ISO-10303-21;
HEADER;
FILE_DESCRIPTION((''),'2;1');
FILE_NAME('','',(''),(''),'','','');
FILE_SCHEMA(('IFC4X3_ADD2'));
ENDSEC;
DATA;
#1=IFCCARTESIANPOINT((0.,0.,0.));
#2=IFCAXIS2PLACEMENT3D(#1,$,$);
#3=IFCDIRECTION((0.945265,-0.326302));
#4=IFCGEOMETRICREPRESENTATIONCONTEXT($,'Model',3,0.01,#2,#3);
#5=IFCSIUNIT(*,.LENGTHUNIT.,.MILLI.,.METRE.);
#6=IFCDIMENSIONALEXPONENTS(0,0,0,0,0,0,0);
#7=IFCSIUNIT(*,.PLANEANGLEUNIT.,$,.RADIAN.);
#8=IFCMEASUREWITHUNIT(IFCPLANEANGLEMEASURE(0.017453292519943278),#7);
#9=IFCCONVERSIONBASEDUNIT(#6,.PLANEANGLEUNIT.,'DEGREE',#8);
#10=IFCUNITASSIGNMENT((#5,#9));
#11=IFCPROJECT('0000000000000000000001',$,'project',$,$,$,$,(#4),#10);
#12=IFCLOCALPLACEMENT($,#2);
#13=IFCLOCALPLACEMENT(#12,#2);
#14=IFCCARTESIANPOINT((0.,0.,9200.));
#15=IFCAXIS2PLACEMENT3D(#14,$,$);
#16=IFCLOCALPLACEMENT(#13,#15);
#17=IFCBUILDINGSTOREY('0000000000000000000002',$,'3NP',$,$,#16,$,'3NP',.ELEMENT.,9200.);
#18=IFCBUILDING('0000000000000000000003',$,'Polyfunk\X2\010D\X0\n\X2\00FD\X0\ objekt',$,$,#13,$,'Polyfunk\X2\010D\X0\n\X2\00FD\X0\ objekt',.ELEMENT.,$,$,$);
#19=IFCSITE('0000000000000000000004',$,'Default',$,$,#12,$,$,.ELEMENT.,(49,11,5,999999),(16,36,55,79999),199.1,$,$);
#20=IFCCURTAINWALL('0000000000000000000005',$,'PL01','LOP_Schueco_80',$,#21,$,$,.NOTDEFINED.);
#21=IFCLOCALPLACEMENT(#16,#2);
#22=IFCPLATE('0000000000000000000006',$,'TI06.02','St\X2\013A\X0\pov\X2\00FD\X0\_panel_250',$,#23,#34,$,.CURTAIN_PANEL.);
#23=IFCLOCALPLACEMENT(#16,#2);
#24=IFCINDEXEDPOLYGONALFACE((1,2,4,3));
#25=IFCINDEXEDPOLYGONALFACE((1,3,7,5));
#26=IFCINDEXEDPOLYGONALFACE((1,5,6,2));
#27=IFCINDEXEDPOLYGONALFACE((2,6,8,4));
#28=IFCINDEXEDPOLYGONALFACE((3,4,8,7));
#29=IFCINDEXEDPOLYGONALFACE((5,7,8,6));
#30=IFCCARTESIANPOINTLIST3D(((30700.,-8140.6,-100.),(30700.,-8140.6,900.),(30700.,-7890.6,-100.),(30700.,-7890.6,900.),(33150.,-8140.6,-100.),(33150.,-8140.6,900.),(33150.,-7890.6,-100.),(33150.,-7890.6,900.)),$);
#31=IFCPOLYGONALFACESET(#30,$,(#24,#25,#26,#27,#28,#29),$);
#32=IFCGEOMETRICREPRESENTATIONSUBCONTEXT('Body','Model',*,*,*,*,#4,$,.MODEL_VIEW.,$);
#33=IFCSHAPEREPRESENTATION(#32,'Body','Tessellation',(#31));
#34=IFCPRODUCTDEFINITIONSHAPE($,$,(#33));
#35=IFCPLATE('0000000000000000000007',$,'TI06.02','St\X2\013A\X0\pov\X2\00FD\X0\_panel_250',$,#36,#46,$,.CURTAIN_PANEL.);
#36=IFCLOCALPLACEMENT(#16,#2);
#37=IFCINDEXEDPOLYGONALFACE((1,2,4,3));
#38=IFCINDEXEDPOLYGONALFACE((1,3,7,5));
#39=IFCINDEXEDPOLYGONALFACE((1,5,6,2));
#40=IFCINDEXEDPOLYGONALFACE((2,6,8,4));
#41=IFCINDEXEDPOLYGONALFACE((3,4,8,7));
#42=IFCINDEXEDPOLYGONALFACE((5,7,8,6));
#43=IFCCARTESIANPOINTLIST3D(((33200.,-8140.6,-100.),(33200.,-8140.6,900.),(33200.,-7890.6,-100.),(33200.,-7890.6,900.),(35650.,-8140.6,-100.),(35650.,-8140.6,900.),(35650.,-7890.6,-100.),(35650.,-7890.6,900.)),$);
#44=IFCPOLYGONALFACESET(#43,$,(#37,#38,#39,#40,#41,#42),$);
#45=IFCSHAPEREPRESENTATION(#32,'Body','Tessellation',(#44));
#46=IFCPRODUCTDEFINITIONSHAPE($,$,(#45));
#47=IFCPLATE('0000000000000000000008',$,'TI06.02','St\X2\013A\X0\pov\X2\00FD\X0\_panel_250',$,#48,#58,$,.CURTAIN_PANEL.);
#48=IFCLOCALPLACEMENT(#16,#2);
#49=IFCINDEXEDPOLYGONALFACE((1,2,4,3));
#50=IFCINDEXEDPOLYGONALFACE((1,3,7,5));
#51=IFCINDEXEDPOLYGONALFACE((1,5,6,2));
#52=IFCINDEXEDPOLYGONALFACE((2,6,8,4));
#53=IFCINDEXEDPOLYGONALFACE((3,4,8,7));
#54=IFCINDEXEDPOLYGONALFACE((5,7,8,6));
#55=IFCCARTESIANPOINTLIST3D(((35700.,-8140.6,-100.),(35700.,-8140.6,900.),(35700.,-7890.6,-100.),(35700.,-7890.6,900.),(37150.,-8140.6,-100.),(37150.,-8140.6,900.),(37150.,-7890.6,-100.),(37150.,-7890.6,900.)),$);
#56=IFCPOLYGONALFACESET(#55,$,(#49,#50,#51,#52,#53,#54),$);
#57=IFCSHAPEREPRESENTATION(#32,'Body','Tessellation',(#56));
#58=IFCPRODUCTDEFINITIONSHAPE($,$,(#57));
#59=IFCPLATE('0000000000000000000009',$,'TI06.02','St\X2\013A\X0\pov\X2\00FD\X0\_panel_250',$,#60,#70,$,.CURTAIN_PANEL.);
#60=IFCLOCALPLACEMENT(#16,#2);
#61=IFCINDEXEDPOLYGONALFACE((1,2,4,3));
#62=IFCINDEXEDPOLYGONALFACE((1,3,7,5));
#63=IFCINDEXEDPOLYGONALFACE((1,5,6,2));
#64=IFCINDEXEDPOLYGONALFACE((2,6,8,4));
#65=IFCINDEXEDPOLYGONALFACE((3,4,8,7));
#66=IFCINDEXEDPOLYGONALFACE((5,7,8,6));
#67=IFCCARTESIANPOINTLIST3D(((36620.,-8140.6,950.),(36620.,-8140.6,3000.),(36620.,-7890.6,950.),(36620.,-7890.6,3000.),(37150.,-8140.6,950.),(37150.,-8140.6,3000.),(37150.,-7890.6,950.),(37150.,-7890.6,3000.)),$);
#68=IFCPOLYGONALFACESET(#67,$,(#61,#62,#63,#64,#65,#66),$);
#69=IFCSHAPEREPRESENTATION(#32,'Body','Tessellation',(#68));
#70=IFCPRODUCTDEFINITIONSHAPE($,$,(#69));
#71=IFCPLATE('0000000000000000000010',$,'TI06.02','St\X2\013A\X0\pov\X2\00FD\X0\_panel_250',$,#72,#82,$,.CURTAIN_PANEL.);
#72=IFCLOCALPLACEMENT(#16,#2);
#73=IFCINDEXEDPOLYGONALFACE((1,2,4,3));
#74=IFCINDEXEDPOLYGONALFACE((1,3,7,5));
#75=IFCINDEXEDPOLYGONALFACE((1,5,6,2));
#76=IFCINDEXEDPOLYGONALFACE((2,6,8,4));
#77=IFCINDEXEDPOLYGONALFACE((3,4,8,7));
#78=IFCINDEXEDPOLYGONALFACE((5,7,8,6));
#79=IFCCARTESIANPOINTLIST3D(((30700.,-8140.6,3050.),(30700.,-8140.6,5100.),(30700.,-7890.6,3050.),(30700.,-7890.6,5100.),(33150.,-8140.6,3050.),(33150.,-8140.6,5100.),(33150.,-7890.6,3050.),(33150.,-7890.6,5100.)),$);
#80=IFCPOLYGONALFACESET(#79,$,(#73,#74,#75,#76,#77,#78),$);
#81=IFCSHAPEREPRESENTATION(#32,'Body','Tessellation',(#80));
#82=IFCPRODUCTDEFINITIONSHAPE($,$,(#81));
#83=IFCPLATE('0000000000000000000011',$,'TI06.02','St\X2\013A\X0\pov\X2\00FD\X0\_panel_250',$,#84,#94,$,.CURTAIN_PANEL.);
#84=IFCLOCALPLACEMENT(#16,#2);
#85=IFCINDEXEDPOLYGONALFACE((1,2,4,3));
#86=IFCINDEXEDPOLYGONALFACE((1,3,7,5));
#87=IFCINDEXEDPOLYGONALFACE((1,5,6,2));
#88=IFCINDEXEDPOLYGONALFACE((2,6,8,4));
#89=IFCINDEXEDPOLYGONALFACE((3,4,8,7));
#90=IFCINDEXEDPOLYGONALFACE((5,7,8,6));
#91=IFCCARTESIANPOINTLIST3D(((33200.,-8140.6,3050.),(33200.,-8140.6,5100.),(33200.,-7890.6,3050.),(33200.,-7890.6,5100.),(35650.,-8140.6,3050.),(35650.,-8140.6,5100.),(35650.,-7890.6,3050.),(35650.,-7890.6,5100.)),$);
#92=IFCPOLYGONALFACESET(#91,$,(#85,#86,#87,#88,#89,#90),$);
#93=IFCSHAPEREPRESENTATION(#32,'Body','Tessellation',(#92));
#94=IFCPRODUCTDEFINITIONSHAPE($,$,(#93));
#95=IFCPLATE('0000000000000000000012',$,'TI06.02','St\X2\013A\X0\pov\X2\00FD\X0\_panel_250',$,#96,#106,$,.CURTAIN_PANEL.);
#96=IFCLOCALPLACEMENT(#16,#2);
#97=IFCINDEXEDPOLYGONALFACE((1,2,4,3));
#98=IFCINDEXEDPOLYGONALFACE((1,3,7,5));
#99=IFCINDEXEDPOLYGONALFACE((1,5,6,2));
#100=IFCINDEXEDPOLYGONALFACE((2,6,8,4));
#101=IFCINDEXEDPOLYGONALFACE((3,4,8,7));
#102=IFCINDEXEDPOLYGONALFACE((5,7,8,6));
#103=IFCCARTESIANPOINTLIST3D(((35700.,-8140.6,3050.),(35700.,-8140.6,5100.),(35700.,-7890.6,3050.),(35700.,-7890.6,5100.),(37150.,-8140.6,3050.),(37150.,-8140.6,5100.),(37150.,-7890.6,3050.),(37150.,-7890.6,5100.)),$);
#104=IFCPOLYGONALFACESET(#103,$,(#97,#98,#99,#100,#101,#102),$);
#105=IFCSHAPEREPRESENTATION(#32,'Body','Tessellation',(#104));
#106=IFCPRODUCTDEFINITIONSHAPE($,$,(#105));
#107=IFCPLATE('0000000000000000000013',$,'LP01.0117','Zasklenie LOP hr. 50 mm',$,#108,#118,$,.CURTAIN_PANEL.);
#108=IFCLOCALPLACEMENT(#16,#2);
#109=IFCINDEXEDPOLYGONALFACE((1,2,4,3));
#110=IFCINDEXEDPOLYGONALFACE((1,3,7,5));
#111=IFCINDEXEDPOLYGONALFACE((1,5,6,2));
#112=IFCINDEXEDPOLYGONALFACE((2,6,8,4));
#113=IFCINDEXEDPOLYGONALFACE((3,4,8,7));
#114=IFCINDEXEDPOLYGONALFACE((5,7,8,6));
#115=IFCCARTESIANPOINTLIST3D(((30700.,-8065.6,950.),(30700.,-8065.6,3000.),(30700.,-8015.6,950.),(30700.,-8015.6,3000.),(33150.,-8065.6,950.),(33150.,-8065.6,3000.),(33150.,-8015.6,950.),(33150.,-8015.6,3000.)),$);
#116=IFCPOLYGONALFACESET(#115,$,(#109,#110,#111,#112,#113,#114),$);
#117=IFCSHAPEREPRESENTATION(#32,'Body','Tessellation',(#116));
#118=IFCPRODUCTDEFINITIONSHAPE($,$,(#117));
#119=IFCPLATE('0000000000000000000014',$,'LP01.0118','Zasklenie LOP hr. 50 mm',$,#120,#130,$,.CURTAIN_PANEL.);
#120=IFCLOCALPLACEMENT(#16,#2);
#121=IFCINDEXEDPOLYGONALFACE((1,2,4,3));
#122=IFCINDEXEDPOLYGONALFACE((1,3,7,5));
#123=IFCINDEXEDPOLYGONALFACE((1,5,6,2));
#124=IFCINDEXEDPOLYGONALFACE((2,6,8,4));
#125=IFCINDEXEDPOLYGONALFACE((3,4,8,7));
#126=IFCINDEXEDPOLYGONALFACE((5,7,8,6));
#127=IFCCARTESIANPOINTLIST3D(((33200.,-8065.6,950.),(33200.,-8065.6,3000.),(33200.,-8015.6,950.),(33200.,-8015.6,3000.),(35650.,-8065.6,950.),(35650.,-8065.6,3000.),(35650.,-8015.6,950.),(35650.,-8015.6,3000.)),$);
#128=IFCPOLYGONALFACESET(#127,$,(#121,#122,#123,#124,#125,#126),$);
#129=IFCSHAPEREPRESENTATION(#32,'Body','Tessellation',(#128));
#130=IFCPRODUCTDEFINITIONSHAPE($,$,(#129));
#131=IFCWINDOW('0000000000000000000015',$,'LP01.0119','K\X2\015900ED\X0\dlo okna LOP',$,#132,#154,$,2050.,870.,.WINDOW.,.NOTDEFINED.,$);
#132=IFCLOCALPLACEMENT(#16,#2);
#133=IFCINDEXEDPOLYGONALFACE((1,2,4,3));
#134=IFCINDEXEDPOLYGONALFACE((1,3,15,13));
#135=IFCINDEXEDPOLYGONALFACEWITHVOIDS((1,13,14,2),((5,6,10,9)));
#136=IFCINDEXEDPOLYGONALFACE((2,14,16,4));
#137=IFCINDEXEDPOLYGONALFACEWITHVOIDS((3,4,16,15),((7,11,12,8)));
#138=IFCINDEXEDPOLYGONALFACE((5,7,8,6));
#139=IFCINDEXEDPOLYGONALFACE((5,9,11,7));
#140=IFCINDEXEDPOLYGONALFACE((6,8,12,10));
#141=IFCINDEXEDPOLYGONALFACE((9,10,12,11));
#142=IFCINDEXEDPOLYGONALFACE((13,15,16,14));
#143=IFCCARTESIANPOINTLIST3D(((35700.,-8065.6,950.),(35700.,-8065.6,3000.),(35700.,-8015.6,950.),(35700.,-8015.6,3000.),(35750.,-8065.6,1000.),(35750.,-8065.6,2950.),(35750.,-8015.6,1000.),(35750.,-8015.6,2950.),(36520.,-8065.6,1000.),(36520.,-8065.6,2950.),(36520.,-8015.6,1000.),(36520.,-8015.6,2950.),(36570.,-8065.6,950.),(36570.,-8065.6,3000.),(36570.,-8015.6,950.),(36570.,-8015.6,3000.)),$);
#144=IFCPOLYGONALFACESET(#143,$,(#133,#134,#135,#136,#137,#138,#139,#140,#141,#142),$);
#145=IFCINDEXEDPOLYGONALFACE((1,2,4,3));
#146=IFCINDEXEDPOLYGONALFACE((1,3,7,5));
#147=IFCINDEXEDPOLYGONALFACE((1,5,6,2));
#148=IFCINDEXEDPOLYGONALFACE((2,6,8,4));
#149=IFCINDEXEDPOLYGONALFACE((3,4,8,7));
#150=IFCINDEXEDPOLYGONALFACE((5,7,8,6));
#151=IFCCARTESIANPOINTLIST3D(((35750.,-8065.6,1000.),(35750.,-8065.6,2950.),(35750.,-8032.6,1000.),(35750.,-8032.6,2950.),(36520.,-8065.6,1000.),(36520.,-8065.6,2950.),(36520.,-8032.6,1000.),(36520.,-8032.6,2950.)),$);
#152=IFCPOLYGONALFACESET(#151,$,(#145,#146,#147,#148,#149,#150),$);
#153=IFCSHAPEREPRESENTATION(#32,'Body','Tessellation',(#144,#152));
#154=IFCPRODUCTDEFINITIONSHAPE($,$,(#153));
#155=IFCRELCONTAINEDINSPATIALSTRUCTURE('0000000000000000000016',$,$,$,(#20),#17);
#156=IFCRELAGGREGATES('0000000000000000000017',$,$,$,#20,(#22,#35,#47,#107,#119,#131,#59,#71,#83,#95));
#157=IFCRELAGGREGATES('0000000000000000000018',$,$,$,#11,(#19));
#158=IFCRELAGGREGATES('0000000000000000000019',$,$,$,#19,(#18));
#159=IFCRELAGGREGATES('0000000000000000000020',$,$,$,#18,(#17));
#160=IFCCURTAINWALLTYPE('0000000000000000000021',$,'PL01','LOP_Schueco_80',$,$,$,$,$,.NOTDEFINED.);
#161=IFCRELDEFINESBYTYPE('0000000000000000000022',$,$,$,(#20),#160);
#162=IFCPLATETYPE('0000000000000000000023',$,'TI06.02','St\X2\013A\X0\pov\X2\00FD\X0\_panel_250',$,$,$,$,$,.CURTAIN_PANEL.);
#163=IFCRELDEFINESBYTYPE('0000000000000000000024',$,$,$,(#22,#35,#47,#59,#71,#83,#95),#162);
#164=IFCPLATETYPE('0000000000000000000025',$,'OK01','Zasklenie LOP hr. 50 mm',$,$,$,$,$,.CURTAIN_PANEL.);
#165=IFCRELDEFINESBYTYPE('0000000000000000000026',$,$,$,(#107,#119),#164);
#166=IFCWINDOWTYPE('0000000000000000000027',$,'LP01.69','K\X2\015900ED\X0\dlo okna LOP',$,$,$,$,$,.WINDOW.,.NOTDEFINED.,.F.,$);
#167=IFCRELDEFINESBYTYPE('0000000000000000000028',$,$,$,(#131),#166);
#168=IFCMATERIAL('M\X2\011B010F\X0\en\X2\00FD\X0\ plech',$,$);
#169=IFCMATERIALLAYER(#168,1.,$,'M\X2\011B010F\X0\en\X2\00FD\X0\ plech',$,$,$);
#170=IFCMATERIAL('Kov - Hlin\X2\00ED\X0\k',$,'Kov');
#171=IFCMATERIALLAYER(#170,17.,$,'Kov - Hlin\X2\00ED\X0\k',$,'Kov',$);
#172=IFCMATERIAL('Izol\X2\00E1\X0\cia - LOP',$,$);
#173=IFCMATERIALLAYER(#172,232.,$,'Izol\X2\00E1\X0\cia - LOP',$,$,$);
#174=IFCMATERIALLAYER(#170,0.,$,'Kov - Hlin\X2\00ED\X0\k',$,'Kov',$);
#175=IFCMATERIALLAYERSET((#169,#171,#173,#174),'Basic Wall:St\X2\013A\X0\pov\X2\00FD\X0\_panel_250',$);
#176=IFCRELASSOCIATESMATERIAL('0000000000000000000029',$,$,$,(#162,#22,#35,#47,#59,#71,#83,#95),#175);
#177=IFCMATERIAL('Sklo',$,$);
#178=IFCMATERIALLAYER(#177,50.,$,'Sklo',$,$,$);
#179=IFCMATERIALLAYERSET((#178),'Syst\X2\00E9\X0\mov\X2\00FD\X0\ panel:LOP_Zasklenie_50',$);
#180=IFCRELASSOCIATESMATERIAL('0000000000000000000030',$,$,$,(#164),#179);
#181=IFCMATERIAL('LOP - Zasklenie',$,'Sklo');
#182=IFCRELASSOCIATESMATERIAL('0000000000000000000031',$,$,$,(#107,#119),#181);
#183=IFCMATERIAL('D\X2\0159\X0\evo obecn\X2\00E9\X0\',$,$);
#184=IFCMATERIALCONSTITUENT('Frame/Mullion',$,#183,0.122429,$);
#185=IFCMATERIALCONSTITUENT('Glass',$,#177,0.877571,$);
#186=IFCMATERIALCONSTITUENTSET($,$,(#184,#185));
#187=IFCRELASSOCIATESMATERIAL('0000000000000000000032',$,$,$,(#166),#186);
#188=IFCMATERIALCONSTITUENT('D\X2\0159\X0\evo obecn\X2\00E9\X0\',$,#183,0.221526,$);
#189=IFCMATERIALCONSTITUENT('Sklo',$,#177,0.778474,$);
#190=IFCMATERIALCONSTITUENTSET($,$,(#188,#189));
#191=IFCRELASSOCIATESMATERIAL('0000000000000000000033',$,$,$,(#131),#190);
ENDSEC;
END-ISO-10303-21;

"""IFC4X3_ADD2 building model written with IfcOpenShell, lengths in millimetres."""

from ifc_helpers import new_model, entity, si_unit, converted_unit, direction, frame, frame_2d, origin, origin_2d_with_axis, place, context, subcontext, project, spatial, polyline, rectangle, outline, extrude, source, transform, mapped, material, layer, layer_set, layer_usage, constituent, constituent_set, type_object, type_shapes, element, aggregate, save


model = new_model("IFC4X3_ADD2")

# Units and contexts
model_context = context("Model", 3, precision=0.01, world=origin(), true_north=direction((0.945265, -0.326302)))
body_context = subcontext(model_context, "Body", "Model", "MODEL_VIEW")
ifc_project = project(units=[si_unit("LENGTHUNIT", "METRE", prefix="MILLI"), converted_unit("PLANEANGLEUNIT", "DEGREE", entity("IfcPlaneAngleMeasure", 0.017453292519943278), si_unit("PLANEANGLEUNIT", "RADIAN"), dimensions=[0, 0, 0, 0, 0, 0, 0])], contexts=[model_context])

# Site, building, storey
site_placement = place(None, origin())
site = spatial("IfcSite", under=ifc_project, at=site_placement, Name="Default", CompositionType="ELEMENT", RefLatitude=(49, 11, 5, 999999), RefLongitude=(16, 36, 55, 79999), RefElevation=199.1)
building_placement = place(site_placement, origin())
building = spatial("IfcBuilding", under=site, at=building_placement, Name="Polyfunkčný objekt", LongName="Polyfunkčný objekt", CompositionType="ELEMENT")
storey_placement = place(building_placement, frame((0.0, 0.0, 9200.0)))
storey = spatial("IfcBuildingStorey", under=building, at=storey_placement, Name="3NP", LongName="3NP", CompositionType="ELEMENT", Elevation=9200.0)

# Curtain wall, plates
curtain_wall_type = type_object("IfcCurtainWallType", Name="PL01", Description="LOP_Schueco_80", PredefinedType="NOTDEFINED")
curtain_wall_placement = place(storey_placement, frame((0.0, 0.0, -9200.0)))
curtain_wall = element("IfcCurtainWall", 1, at=curtain_wall_placement, inside=storey, type_object=curtain_wall_type, Name="PL01", Description="LOP_Schueco_80", PredefinedType="NOTDEFINED")
ifc_material_1 = material(Name="Měďený plech")
ifc_layer_1 = layer(ifc_material_1, 1.0, Name="Měďený plech")
ifc_material_2 = material(Name="Kov - Hliník", Category="Kov")
ifc_layer_2 = layer(ifc_material_2, 17.0, Name="Kov - Hliník", Category="Kov")
ifc_material_3 = material(Name="Izolácia - LOP")
ifc_layer_3 = layer(ifc_material_3, 232.0, Name="Izolácia - LOP")
ifc_layer_4 = layer(ifc_material_2, 0.0, Name="Kov - Hliník", Category="Kov")
ifc_layer_set_1 = layer_set([ifc_layer_1, ifc_layer_2, ifc_layer_3, ifc_layer_4], Name="Basic Wall:Stĺpový_panel_250")
ifc_layer_usage_1 = layer_usage(ifc_layer_set_1, "AXIS2", "POSITIVE", -125.0)
plate_type_1 = type_object("IfcPlateType", Name="TI06.02", Description="Stĺpový_panel_250", PredefinedType="CURTAIN_PANEL", material=ifc_layer_set_1)
plate_1_placement = place(storey_placement, frame((30700.0, -8015.6, -100.0)))
plate_1 = element("IfcPlate", 2, at=plate_1_placement, type_object=plate_type_1, material=ifc_layer_usage_1, Name="TI06.02", Description="Stĺpový_panel_250", PredefinedType="CURTAIN_PANEL", context=body_context, shape_type="SweptSolid", body=[
    extrude(rectangle(XDim=250.0, YDim=2450.0, at=frame_2d((0.0, 0.0), x_axis=(1.0, 0.0))), frame((1225.0, 0.0, 0.0), z_axis=(0.0, 0.0, 1.0), x_axis=(0.0, 1.0, 0.0)), (0.0, 0.0, 1.0), 1000.0),
])
ifc_layer_usage_2 = layer_usage(ifc_layer_set_1, "AXIS2", "POSITIVE", -125.0)
plate_2_placement = place(storey_placement, frame((33200.0, -8015.6, -100.0)))
plate_2 = element("IfcPlate", 3, at=plate_2_placement, type_object=plate_type_1, material=ifc_layer_usage_2, Name="TI06.02", Description="Stĺpový_panel_250", PredefinedType="CURTAIN_PANEL", context=body_context, shape_type="SweptSolid", body=[
    extrude(rectangle(XDim=250.0, YDim=2450.0, at=frame_2d((0.0, 0.0), x_axis=(1.0, 0.0))), frame((1225.0, 0.0, 0.0), z_axis=(0.0, 0.0, 1.0), x_axis=(0.0, 1.0, 0.0)), (0.0, 0.0, 1.0), 1000.0),
])
ifc_layer_usage_3 = layer_usage(ifc_layer_set_1, "AXIS2", "POSITIVE", -125.0)
plate_3_placement = place(storey_placement, frame((35700.0, -8015.6, -100.0)))
plate_3 = element("IfcPlate", 4, at=plate_3_placement, type_object=plate_type_1, material=ifc_layer_usage_3, Name="TI06.02", Description="Stĺpový_panel_250", PredefinedType="CURTAIN_PANEL", context=body_context, shape_type="SweptSolid", body=[
    extrude(rectangle(XDim=250.0, YDim=1450.0, at=frame_2d((0.0, 0.0), x_axis=(1.0, 0.0))), frame((725.0, 0.0, 0.0), z_axis=(0.0, 0.0, 1.0), x_axis=(0.0, 1.0, 0.0)), (0.0, 0.0, 1.0), 1000.0),
])
ifc_layer_usage_4 = layer_usage(ifc_layer_set_1, "AXIS2", "POSITIVE", -125.0)
plate_4_placement = place(storey_placement, frame((36620.0, -8015.6, 950.0)))
plate_4 = element("IfcPlate", 5, at=plate_4_placement, type_object=plate_type_1, material=ifc_layer_usage_4, Name="TI06.02", Description="Stĺpový_panel_250", PredefinedType="CURTAIN_PANEL", context=body_context, shape_type="SweptSolid", body=[
    extrude(rectangle(XDim=250.0, YDim=530.0, at=frame_2d((0.0, 0.0), x_axis=(1.0, 0.0))), frame((265.0, 0.0, 0.0), z_axis=(0.0, 0.0, 1.0), x_axis=(0.0, 1.0, 0.0)), (0.0, 0.0, 1.0), 2050.0),
])
ifc_layer_usage_5 = layer_usage(ifc_layer_set_1, "AXIS2", "POSITIVE", -125.0)
plate_5_placement = place(storey_placement, frame((30700.0, -8015.6, 3050.0)))
plate_5 = element("IfcPlate", 6, at=plate_5_placement, type_object=plate_type_1, material=ifc_layer_usage_5, Name="TI06.02", Description="Stĺpový_panel_250", PredefinedType="CURTAIN_PANEL", context=body_context, shape_type="SweptSolid", body=[
    extrude(rectangle(XDim=250.0, YDim=2450.0, at=frame_2d((0.0, 0.0), x_axis=(1.0, 0.0))), frame((1225.0, 0.0, 0.0), z_axis=(0.0, 0.0, 1.0), x_axis=(0.0, 1.0, 0.0)), (0.0, 0.0, 1.0), 2050.0),
])
ifc_layer_usage_6 = layer_usage(ifc_layer_set_1, "AXIS2", "POSITIVE", -125.0)
plate_6_placement = place(storey_placement, frame((33200.0, -8015.6, 3050.0)))
plate_6 = element("IfcPlate", 7, at=plate_6_placement, type_object=plate_type_1, material=ifc_layer_usage_6, Name="TI06.02", Description="Stĺpový_panel_250", PredefinedType="CURTAIN_PANEL", context=body_context, shape_type="SweptSolid", body=[
    extrude(rectangle(XDim=250.0, YDim=2450.0, at=frame_2d((0.0, 0.0), x_axis=(1.0, 0.0))), frame((1225.0, 0.0, 0.0), z_axis=(0.0, 0.0, 1.0), x_axis=(0.0, 1.0, 0.0)), (0.0, 0.0, 1.0), 2050.0),
])
ifc_layer_usage_7 = layer_usage(ifc_layer_set_1, "AXIS2", "POSITIVE", -125.0)
plate_7_placement = place(storey_placement, frame((35700.0, -8015.6, 3050.0)))
plate_7 = element("IfcPlate", 8, at=plate_7_placement, type_object=plate_type_1, material=ifc_layer_usage_7, Name="TI06.02", Description="Stĺpový_panel_250", PredefinedType="CURTAIN_PANEL", context=body_context, shape_type="SweptSolid", body=[
    extrude(rectangle(XDim=250.0, YDim=1450.0, at=frame_2d((0.0, 0.0), x_axis=(1.0, 0.0))), frame((725.0, 0.0, 0.0), z_axis=(0.0, 0.0, 1.0), x_axis=(0.0, 1.0, 0.0)), (0.0, 0.0, 1.0), 2050.0),
])
ifc_material_4 = material(Name="LOP - Zasklenie", Category="Sklo")
ifc_material_5 = material(Name="Sklo")
ifc_layer_5 = layer(ifc_material_5, 50.0, Name="Sklo")
ifc_layer_set_2 = layer_set([ifc_layer_5], Name="Systémový panel:LOP_Zasklenie_50")
plate_type_2 = type_object("IfcPlateType", Name="OK01", Description="Zasklenie LOP hr. 50 mm", PredefinedType="CURTAIN_PANEL", material=ifc_layer_set_2)
shared_shape_1 = source(origin(), body_context, "Body", "SweptSolid", [
    extrude(rectangle(XDim=50.0, YDim=2450.0, at=origin_2d_with_axis()), frame((0.0, -25.0, 0.0), z_axis=(0.0, 0.0, 1.0), x_axis=(0.0, 1.0, 0.0)), (0.0, 0.0, 1.0), 2050.0),
])
type_shapes(plate_type_2, [shared_shape_1])
plate_8_placement = place(curtain_wall_placement, frame((31925.0, -8015.6, 10150.0)))
plate_8 = element("IfcPlate", 9, at=plate_8_placement, type_object=plate_type_2, material=ifc_material_4, Name="LP01.0117", Description="Zasklenie LOP hr. 50 mm", PredefinedType="CURTAIN_PANEL", context=body_context, shape_type="MappedRepresentation", body=[
    mapped(shared_shape_1, transform((0.0, 0.0, 0.0), scale=1.0)),
])
plate_9_placement = place(curtain_wall_placement, frame((34425.0, -8015.6, 10150.0)))
plate_9 = element("IfcPlate", 10, at=plate_9_placement, type_object=plate_type_2, material=ifc_material_4, Name="LP01.0118", Description="Zasklenie LOP hr. 50 mm", PredefinedType="CURTAIN_PANEL", context=body_context, shape_type="MappedRepresentation", body=[
    mapped(shared_shape_1, transform((0.0, 0.0, 0.0), scale=1.0)),
])

# Window
ifc_material_6 = material(Name="Dřevo obecné")
ifc_constituent_1 = constituent(ifc_material_6, Name="Dřevo obecné", fraction=0.221526)
ifc_constituent_2 = constituent(ifc_material_5, Name="Sklo", fraction=0.778474)
ifc_constituent_set_1 = constituent_set(constituents=[ifc_constituent_1, ifc_constituent_2])
ifc_constituent_3 = constituent(ifc_material_6, Name="Frame/Mullion", fraction=0.122429)
ifc_constituent_4 = constituent(ifc_material_5, Name="Glass", fraction=0.877571)
ifc_constituent_set_2 = constituent_set(constituents=[ifc_constituent_3, ifc_constituent_4])
window_type = type_object("IfcWindowType", Name="LP01.69", Description="Křídlo okna LOP", ParameterTakesPrecedence=False, PartitioningType="NOTDEFINED", PredefinedType="WINDOW", material=ifc_constituent_set_2)
shared_shape_2 = source(origin(), body_context, "Body", "SweptSolid", [
    extrude(outline(polyline([(-1025.0, -435.0), (1025.0, -435.0), (1025.0, 435.0), (-1025.0, 435.0), (-1025.0, -435.0)]), holes=[polyline([(-975.0, -385.0), (-975.0, 385.0), (975.0, 385.0), (975.0, -385.0), (-975.0, -385.0)])]), frame((0.0, 50.0, 1025.0), z_axis=(0.0, -1.0, 0.0), x_axis=(0.0, 0.0, -1.0)), (0.0, 0.0, 1.0), 50.0),
    extrude(rectangle(XDim=770.0, YDim=33.0, at=frame_2d((0.0, 0.0), x_axis=(1.0, 0.0))), frame((0.0, 33.5, 50.0), z_axis=(0.0, 0.0, 1.0), x_axis=(-1.0, 0.0, 0.0)), (0.0, 0.0, 1.0), 1950.0),
])
type_shapes(window_type, [shared_shape_2])
window_placement = place(curtain_wall_placement, frame((36135.0, -8015.6, 10150.0), z_axis=(0.0, 0.0, 1.0), x_axis=(-1.0, 0.0, 0.0)))
window = element("IfcWindow", 11, at=window_placement, type_object=window_type, material=ifc_constituent_set_1, Name="LP01.0119", Description="Křídlo okna LOP", OverallHeight=2050.0, OverallWidth=870.0, PartitioningType="NOTDEFINED", PredefinedType="WINDOW", context=body_context, shape_type="MappedRepresentation", body=[
    mapped(shared_shape_2, transform((0.0, 0.0, 0.0), scale=1.0)),
])
aggregate(curtain_wall, [plate_1, plate_2, plate_3, plate_8, plate_9, window, plate_4, plate_5, plate_6, plate_7])

save(model, "model.ifc")
